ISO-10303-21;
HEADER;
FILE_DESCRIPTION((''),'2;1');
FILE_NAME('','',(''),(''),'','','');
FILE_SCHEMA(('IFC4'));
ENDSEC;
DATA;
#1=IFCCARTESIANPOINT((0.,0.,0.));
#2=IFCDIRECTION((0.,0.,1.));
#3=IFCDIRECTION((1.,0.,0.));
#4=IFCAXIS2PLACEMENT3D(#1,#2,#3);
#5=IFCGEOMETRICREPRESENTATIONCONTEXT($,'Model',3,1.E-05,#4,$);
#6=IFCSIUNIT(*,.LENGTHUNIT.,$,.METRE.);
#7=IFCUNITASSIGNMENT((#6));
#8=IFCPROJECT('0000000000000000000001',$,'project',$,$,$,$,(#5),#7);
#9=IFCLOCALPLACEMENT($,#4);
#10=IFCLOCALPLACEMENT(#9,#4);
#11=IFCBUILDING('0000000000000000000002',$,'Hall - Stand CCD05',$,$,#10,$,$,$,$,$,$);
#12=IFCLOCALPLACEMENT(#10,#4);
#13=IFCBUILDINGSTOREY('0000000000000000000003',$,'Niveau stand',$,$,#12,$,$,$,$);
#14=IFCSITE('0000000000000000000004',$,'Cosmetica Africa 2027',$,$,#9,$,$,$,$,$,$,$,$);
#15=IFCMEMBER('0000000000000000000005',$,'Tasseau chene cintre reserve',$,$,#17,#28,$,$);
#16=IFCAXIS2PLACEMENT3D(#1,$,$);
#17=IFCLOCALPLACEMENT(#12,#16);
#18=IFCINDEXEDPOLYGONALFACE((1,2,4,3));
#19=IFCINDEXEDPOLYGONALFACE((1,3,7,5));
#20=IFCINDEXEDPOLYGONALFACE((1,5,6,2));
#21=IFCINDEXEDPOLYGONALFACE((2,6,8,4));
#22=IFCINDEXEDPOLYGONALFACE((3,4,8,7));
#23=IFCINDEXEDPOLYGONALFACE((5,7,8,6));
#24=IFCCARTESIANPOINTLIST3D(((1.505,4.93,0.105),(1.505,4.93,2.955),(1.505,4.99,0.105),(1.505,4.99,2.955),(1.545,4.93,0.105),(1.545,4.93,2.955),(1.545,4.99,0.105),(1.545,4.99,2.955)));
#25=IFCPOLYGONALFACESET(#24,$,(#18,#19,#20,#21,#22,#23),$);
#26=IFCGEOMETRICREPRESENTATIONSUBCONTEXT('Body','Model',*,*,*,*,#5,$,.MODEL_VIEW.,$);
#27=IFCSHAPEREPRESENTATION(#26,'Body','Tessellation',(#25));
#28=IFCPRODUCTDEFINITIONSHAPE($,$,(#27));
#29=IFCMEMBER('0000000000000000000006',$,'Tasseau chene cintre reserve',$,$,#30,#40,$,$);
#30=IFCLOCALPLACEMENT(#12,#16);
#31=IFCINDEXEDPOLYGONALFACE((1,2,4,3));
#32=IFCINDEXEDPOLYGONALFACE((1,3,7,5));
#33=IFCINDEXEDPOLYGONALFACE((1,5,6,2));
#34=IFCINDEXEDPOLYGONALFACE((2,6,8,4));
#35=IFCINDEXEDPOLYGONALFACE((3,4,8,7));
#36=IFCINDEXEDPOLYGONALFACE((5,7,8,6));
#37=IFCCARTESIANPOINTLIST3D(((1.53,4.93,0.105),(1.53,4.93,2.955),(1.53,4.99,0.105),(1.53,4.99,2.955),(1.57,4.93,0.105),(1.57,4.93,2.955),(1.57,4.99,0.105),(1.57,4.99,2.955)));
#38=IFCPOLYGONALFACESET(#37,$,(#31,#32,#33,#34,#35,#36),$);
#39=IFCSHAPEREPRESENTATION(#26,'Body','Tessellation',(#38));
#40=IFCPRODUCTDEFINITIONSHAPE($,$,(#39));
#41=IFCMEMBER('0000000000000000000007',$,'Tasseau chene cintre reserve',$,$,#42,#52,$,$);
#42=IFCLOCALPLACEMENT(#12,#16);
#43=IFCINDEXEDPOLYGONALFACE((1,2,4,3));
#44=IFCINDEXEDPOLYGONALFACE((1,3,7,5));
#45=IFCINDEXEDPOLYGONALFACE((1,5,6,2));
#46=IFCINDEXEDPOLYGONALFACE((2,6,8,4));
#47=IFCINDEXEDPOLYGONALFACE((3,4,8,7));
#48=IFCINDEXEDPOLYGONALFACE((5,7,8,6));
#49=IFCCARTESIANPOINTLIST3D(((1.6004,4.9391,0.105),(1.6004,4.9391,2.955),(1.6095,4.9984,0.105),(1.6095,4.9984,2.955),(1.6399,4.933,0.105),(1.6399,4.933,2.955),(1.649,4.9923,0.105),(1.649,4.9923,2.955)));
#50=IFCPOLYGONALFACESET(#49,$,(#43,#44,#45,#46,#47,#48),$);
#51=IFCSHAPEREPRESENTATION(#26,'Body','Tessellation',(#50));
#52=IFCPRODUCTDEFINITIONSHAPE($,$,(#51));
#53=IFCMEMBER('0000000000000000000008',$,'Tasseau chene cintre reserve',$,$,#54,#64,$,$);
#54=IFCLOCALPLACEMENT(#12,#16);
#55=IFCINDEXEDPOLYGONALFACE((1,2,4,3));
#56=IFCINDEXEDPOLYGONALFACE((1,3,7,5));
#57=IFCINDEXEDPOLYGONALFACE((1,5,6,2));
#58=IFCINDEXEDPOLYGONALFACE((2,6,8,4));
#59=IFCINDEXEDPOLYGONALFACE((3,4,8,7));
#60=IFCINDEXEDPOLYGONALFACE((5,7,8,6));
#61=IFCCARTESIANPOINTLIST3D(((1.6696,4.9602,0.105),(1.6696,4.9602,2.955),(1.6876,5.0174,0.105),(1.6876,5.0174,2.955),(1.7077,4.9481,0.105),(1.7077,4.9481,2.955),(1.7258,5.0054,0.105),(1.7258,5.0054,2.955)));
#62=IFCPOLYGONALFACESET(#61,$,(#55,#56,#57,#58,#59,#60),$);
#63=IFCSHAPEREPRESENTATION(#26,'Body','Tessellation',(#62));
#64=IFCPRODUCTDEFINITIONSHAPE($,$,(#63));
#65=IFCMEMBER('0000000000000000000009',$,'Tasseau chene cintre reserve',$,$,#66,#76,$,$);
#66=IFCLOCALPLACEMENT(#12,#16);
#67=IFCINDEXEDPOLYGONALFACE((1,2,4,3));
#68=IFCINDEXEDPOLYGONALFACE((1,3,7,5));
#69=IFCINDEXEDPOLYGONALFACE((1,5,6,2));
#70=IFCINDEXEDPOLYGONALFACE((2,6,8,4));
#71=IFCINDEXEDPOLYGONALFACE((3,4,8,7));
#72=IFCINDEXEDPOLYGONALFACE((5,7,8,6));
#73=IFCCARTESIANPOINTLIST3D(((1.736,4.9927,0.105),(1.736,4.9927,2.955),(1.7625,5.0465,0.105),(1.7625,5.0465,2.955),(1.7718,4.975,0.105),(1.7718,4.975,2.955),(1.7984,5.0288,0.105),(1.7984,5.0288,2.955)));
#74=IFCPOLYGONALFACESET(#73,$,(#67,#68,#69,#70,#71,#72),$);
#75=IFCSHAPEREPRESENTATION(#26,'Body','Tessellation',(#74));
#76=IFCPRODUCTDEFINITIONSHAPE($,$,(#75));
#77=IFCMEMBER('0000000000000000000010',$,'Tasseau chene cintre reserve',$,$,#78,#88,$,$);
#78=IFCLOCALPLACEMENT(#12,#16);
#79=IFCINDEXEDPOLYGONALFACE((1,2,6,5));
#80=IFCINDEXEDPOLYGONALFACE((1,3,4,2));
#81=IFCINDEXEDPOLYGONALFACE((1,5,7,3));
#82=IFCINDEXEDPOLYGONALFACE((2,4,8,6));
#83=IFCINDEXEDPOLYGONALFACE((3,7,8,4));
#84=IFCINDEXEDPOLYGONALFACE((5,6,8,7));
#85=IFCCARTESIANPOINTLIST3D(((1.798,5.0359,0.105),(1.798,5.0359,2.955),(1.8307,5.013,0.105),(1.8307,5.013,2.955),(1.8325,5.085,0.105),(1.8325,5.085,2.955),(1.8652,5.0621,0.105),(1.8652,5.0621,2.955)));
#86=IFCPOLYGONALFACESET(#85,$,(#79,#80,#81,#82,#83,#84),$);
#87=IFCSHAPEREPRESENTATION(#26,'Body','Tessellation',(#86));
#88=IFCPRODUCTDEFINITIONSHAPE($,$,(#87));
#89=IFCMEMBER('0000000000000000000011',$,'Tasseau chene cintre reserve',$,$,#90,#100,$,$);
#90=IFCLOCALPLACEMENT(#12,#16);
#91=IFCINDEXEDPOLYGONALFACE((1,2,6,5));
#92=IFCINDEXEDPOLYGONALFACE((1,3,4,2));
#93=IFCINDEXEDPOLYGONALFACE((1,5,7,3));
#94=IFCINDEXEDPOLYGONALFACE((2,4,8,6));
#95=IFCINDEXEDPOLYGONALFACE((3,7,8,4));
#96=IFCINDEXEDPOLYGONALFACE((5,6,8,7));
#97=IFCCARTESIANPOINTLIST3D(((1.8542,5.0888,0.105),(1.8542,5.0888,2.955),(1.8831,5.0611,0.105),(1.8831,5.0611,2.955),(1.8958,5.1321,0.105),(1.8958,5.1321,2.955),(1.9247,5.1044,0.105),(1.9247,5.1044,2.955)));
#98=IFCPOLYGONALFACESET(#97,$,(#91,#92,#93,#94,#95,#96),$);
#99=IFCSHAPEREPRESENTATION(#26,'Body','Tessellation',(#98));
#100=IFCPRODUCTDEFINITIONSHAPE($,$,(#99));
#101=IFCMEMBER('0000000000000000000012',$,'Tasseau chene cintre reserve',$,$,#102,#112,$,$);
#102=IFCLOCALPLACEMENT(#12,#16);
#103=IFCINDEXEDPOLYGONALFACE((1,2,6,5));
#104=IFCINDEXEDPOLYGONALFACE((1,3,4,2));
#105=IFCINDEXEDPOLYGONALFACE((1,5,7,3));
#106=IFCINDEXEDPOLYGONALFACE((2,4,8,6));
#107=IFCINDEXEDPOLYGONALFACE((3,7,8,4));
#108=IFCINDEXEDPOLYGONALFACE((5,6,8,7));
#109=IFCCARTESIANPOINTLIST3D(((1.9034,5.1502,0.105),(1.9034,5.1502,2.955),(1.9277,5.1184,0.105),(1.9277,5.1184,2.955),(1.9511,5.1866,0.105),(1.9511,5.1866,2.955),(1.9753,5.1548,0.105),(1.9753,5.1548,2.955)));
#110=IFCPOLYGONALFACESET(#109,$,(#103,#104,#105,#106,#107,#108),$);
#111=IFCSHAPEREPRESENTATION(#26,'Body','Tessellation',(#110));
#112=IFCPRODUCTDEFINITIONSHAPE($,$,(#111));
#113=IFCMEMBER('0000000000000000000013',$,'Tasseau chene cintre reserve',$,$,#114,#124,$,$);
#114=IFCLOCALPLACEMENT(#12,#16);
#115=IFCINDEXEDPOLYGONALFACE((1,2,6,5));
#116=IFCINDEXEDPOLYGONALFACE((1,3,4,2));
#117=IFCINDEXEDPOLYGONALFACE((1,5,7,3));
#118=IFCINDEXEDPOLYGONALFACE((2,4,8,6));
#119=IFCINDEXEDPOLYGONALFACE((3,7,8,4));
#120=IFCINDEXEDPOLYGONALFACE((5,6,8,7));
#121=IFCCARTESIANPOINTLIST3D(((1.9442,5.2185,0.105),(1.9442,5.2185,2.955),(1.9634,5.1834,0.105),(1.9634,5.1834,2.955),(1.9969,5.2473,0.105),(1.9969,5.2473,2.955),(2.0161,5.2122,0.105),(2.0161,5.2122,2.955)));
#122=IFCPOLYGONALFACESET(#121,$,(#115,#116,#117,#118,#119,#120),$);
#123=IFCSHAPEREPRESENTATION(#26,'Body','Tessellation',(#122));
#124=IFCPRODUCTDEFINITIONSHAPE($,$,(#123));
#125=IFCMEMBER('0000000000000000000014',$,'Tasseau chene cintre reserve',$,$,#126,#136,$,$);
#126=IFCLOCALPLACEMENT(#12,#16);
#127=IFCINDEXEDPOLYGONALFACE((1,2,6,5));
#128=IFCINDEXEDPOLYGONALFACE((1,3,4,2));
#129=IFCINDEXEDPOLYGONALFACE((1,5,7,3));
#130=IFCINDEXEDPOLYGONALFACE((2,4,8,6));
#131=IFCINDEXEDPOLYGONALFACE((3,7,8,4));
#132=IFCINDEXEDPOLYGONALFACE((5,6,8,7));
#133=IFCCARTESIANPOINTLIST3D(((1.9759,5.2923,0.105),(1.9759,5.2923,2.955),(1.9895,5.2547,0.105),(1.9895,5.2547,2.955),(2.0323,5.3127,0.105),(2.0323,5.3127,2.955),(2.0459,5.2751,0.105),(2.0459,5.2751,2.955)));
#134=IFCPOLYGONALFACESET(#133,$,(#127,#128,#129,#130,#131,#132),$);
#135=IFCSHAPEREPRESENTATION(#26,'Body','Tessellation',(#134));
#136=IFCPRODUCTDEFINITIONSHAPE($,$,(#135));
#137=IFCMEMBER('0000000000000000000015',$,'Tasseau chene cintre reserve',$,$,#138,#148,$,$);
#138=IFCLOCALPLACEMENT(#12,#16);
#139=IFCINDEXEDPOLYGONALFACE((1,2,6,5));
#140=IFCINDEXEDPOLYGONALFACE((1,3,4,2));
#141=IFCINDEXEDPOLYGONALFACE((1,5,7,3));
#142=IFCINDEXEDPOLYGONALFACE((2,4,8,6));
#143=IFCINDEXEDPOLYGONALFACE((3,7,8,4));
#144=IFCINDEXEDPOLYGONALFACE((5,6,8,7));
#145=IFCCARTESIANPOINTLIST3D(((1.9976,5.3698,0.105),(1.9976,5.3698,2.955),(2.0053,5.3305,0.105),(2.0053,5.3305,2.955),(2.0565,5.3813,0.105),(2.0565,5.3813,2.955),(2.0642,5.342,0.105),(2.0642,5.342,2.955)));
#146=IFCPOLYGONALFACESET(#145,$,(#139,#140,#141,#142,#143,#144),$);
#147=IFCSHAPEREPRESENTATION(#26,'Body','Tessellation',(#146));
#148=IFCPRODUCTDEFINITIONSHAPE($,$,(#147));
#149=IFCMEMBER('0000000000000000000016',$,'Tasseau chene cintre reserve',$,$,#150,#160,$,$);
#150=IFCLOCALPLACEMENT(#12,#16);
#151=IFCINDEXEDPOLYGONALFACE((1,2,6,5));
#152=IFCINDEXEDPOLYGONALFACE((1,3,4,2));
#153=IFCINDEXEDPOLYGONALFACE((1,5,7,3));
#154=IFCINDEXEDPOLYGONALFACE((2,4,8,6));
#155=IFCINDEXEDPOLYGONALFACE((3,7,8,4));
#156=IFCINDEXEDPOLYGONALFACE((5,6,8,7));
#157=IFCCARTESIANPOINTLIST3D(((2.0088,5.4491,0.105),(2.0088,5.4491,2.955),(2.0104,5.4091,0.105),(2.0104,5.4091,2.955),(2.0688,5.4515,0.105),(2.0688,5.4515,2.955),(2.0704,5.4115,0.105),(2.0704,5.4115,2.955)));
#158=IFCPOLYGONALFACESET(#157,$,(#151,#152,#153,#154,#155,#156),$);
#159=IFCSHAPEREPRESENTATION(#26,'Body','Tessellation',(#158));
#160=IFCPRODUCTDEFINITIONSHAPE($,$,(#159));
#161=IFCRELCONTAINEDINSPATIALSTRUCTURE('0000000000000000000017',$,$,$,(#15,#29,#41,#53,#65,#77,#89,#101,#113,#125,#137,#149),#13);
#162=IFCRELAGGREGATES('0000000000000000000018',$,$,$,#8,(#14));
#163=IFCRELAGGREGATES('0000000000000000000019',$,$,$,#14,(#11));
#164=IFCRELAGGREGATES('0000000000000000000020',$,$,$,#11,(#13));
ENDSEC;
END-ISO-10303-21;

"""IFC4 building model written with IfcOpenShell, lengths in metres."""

from ifc_helpers import new_model, si_unit, frame, origin_with_axes, place, context, subcontext, project, spatial, polyline, outline, extrude, element, save


model = new_model("IFC4")

# Units and contexts
model_context = context("Model", 3, precision=1e-05, world=origin_with_axes())
body_context = subcontext(model_context, "Body", "Model", "MODEL_VIEW")
ifc_project = project(units=[si_unit("LENGTHUNIT", "METRE")], contexts=[model_context])

# Site, building, storey
site_placement = place(None, origin_with_axes())
site = spatial("IfcSite", under=ifc_project, at=site_placement, Name="Cosmetica Africa 2027")
building_placement = place(site_placement, origin_with_axes())
building = spatial("IfcBuilding", under=site, at=building_placement, Name="Hall - Stand CCD05")
storey_placement = place(building_placement, origin_with_axes())
storey = spatial("IfcBuildingStorey", under=building, at=storey_placement, Name="Niveau stand")

# Members
member_1_placement = place(storey_placement, origin_with_axes())
element("IfcMember", 1, at=member_1_placement, inside=storey, Name="Tasseau chene cintre reserve", context=body_context, shape_type="SweptSolid", body=[
    extrude(outline(polyline([(1.505, 4.93), (1.545, 4.93), (1.545, 4.99), (1.505, 4.99), (1.505, 4.93)])), frame((0.0, 0.0, 0.105)), (0.0, 0.0, 1.0), 2.85),
])
member_2_placement = place(storey_placement, origin_with_axes())
element("IfcMember", 2, at=member_2_placement, inside=storey, Name="Tasseau chene cintre reserve", context=body_context, shape_type="SweptSolid", body=[
    extrude(outline(polyline([(1.53, 4.93), (1.57, 4.93), (1.57, 4.99), (1.53, 4.99), (1.53, 4.93)])), frame((0.0, 0.0, 0.105)), (0.0, 0.0, 1.0), 2.85),
])
member_3_placement = place(storey_placement, origin_with_axes())
element("IfcMember", 3, at=member_3_placement, inside=storey, Name="Tasseau chene cintre reserve", context=body_context, shape_type="SweptSolid", body=[
    extrude(outline(polyline([(1.6004, 4.9391), (1.6399, 4.933), (1.649, 4.9923), (1.6095, 4.9984), (1.6004, 4.9391)])), frame((0.0, 0.0, 0.105)), (0.0, 0.0, 1.0), 2.85),
])
member_4_placement = place(storey_placement, origin_with_axes())
element("IfcMember", 4, at=member_4_placement, inside=storey, Name="Tasseau chene cintre reserve", context=body_context, shape_type="SweptSolid", body=[
    extrude(outline(polyline([(1.6696, 4.9602), (1.7077, 4.9481), (1.7258, 5.0054), (1.6876, 5.0174), (1.6696, 4.9602)])), frame((0.0, 0.0, 0.105)), (0.0, 0.0, 1.0), 2.85),
])
member_5_placement = place(storey_placement, origin_with_axes())
element("IfcMember", 5, at=member_5_placement, inside=storey, Name="Tasseau chene cintre reserve", context=body_context, shape_type="SweptSolid", body=[
    extrude(outline(polyline([(1.736, 4.9927), (1.7718, 4.975), (1.7984, 5.0288), (1.7625, 5.0465), (1.736, 4.9927)])), frame((0.0, 0.0, 0.105)), (0.0, 0.0, 1.0), 2.85),
])
member_6_placement = place(storey_placement, origin_with_axes())
element("IfcMember", 6, at=member_6_placement, inside=storey, Name="Tasseau chene cintre reserve", context=body_context, shape_type="SweptSolid", body=[
    extrude(outline(polyline([(1.798, 5.0359), (1.8307, 5.013), (1.8652, 5.0621), (1.8325, 5.085), (1.798, 5.0359)])), frame((0.0, 0.0, 0.105)), (0.0, 0.0, 1.0), 2.85),
])
member_7_placement = place(storey_placement, origin_with_axes())
element("IfcMember", 7, at=member_7_placement, inside=storey, Name="Tasseau chene cintre reserve", context=body_context, shape_type="SweptSolid", body=[
    extrude(outline(polyline([(1.8542, 5.0888), (1.8831, 5.0611), (1.9247, 5.1044), (1.8958, 5.1321), (1.8542, 5.0888)])), frame((0.0, 0.0, 0.105)), (0.0, 0.0, 1.0), 2.85),
])
member_8_placement = place(storey_placement, origin_with_axes())
element("IfcMember", 8, at=member_8_placement, inside=storey, Name="Tasseau chene cintre reserve", context=body_context, shape_type="SweptSolid", body=[
    extrude(outline(polyline([(1.9034, 5.1502), (1.9277, 5.1184), (1.9753, 5.1548), (1.9511, 5.1866), (1.9034, 5.1502)])), frame((0.0, 0.0, 0.105)), (0.0, 0.0, 1.0), 2.85),
])
member_9_placement = place(storey_placement, origin_with_axes())
element("IfcMember", 9, at=member_9_placement, inside=storey, Name="Tasseau chene cintre reserve", context=body_context, shape_type="SweptSolid", body=[
    extrude(outline(polyline([(1.9442, 5.2185), (1.9634, 5.1834), (2.0161, 5.2122), (1.9969, 5.2473), (1.9442, 5.2185)])), frame((0.0, 0.0, 0.105)), (0.0, 0.0, 1.0), 2.85),
])
member_10_placement = place(storey_placement, origin_with_axes())
element("IfcMember", 10, at=member_10_placement, inside=storey, Name="Tasseau chene cintre reserve", context=body_context, shape_type="SweptSolid", body=[
    extrude(outline(polyline([(1.9759, 5.2923), (1.9895, 5.2547), (2.0459, 5.2751), (2.0323, 5.3127), (1.9759, 5.2923)])), frame((0.0, 0.0, 0.105)), (0.0, 0.0, 1.0), 2.85),
])
member_11_placement = place(storey_placement, origin_with_axes())
element("IfcMember", 11, at=member_11_placement, inside=storey, Name="Tasseau chene cintre reserve", context=body_context, shape_type="SweptSolid", body=[
    extrude(outline(polyline([(1.9976, 5.3698), (2.0053, 5.3305), (2.0642, 5.342), (2.0565, 5.3813), (1.9976, 5.3698)])), frame((0.0, 0.0, 0.105)), (0.0, 0.0, 1.0), 2.85),
])
member_12_placement = place(storey_placement, origin_with_axes())
element("IfcMember", 12, at=member_12_placement, inside=storey, Name="Tasseau chene cintre reserve", context=body_context, shape_type="SweptSolid", body=[
    extrude(outline(polyline([(2.0088, 5.4491), (2.0104, 5.4091), (2.0704, 5.4115), (2.0688, 5.4515), (2.0088, 5.4491)])), frame((0.0, 0.0, 0.105)), (0.0, 0.0, 1.0), 2.85),
])

save(model, "model.ifc")
